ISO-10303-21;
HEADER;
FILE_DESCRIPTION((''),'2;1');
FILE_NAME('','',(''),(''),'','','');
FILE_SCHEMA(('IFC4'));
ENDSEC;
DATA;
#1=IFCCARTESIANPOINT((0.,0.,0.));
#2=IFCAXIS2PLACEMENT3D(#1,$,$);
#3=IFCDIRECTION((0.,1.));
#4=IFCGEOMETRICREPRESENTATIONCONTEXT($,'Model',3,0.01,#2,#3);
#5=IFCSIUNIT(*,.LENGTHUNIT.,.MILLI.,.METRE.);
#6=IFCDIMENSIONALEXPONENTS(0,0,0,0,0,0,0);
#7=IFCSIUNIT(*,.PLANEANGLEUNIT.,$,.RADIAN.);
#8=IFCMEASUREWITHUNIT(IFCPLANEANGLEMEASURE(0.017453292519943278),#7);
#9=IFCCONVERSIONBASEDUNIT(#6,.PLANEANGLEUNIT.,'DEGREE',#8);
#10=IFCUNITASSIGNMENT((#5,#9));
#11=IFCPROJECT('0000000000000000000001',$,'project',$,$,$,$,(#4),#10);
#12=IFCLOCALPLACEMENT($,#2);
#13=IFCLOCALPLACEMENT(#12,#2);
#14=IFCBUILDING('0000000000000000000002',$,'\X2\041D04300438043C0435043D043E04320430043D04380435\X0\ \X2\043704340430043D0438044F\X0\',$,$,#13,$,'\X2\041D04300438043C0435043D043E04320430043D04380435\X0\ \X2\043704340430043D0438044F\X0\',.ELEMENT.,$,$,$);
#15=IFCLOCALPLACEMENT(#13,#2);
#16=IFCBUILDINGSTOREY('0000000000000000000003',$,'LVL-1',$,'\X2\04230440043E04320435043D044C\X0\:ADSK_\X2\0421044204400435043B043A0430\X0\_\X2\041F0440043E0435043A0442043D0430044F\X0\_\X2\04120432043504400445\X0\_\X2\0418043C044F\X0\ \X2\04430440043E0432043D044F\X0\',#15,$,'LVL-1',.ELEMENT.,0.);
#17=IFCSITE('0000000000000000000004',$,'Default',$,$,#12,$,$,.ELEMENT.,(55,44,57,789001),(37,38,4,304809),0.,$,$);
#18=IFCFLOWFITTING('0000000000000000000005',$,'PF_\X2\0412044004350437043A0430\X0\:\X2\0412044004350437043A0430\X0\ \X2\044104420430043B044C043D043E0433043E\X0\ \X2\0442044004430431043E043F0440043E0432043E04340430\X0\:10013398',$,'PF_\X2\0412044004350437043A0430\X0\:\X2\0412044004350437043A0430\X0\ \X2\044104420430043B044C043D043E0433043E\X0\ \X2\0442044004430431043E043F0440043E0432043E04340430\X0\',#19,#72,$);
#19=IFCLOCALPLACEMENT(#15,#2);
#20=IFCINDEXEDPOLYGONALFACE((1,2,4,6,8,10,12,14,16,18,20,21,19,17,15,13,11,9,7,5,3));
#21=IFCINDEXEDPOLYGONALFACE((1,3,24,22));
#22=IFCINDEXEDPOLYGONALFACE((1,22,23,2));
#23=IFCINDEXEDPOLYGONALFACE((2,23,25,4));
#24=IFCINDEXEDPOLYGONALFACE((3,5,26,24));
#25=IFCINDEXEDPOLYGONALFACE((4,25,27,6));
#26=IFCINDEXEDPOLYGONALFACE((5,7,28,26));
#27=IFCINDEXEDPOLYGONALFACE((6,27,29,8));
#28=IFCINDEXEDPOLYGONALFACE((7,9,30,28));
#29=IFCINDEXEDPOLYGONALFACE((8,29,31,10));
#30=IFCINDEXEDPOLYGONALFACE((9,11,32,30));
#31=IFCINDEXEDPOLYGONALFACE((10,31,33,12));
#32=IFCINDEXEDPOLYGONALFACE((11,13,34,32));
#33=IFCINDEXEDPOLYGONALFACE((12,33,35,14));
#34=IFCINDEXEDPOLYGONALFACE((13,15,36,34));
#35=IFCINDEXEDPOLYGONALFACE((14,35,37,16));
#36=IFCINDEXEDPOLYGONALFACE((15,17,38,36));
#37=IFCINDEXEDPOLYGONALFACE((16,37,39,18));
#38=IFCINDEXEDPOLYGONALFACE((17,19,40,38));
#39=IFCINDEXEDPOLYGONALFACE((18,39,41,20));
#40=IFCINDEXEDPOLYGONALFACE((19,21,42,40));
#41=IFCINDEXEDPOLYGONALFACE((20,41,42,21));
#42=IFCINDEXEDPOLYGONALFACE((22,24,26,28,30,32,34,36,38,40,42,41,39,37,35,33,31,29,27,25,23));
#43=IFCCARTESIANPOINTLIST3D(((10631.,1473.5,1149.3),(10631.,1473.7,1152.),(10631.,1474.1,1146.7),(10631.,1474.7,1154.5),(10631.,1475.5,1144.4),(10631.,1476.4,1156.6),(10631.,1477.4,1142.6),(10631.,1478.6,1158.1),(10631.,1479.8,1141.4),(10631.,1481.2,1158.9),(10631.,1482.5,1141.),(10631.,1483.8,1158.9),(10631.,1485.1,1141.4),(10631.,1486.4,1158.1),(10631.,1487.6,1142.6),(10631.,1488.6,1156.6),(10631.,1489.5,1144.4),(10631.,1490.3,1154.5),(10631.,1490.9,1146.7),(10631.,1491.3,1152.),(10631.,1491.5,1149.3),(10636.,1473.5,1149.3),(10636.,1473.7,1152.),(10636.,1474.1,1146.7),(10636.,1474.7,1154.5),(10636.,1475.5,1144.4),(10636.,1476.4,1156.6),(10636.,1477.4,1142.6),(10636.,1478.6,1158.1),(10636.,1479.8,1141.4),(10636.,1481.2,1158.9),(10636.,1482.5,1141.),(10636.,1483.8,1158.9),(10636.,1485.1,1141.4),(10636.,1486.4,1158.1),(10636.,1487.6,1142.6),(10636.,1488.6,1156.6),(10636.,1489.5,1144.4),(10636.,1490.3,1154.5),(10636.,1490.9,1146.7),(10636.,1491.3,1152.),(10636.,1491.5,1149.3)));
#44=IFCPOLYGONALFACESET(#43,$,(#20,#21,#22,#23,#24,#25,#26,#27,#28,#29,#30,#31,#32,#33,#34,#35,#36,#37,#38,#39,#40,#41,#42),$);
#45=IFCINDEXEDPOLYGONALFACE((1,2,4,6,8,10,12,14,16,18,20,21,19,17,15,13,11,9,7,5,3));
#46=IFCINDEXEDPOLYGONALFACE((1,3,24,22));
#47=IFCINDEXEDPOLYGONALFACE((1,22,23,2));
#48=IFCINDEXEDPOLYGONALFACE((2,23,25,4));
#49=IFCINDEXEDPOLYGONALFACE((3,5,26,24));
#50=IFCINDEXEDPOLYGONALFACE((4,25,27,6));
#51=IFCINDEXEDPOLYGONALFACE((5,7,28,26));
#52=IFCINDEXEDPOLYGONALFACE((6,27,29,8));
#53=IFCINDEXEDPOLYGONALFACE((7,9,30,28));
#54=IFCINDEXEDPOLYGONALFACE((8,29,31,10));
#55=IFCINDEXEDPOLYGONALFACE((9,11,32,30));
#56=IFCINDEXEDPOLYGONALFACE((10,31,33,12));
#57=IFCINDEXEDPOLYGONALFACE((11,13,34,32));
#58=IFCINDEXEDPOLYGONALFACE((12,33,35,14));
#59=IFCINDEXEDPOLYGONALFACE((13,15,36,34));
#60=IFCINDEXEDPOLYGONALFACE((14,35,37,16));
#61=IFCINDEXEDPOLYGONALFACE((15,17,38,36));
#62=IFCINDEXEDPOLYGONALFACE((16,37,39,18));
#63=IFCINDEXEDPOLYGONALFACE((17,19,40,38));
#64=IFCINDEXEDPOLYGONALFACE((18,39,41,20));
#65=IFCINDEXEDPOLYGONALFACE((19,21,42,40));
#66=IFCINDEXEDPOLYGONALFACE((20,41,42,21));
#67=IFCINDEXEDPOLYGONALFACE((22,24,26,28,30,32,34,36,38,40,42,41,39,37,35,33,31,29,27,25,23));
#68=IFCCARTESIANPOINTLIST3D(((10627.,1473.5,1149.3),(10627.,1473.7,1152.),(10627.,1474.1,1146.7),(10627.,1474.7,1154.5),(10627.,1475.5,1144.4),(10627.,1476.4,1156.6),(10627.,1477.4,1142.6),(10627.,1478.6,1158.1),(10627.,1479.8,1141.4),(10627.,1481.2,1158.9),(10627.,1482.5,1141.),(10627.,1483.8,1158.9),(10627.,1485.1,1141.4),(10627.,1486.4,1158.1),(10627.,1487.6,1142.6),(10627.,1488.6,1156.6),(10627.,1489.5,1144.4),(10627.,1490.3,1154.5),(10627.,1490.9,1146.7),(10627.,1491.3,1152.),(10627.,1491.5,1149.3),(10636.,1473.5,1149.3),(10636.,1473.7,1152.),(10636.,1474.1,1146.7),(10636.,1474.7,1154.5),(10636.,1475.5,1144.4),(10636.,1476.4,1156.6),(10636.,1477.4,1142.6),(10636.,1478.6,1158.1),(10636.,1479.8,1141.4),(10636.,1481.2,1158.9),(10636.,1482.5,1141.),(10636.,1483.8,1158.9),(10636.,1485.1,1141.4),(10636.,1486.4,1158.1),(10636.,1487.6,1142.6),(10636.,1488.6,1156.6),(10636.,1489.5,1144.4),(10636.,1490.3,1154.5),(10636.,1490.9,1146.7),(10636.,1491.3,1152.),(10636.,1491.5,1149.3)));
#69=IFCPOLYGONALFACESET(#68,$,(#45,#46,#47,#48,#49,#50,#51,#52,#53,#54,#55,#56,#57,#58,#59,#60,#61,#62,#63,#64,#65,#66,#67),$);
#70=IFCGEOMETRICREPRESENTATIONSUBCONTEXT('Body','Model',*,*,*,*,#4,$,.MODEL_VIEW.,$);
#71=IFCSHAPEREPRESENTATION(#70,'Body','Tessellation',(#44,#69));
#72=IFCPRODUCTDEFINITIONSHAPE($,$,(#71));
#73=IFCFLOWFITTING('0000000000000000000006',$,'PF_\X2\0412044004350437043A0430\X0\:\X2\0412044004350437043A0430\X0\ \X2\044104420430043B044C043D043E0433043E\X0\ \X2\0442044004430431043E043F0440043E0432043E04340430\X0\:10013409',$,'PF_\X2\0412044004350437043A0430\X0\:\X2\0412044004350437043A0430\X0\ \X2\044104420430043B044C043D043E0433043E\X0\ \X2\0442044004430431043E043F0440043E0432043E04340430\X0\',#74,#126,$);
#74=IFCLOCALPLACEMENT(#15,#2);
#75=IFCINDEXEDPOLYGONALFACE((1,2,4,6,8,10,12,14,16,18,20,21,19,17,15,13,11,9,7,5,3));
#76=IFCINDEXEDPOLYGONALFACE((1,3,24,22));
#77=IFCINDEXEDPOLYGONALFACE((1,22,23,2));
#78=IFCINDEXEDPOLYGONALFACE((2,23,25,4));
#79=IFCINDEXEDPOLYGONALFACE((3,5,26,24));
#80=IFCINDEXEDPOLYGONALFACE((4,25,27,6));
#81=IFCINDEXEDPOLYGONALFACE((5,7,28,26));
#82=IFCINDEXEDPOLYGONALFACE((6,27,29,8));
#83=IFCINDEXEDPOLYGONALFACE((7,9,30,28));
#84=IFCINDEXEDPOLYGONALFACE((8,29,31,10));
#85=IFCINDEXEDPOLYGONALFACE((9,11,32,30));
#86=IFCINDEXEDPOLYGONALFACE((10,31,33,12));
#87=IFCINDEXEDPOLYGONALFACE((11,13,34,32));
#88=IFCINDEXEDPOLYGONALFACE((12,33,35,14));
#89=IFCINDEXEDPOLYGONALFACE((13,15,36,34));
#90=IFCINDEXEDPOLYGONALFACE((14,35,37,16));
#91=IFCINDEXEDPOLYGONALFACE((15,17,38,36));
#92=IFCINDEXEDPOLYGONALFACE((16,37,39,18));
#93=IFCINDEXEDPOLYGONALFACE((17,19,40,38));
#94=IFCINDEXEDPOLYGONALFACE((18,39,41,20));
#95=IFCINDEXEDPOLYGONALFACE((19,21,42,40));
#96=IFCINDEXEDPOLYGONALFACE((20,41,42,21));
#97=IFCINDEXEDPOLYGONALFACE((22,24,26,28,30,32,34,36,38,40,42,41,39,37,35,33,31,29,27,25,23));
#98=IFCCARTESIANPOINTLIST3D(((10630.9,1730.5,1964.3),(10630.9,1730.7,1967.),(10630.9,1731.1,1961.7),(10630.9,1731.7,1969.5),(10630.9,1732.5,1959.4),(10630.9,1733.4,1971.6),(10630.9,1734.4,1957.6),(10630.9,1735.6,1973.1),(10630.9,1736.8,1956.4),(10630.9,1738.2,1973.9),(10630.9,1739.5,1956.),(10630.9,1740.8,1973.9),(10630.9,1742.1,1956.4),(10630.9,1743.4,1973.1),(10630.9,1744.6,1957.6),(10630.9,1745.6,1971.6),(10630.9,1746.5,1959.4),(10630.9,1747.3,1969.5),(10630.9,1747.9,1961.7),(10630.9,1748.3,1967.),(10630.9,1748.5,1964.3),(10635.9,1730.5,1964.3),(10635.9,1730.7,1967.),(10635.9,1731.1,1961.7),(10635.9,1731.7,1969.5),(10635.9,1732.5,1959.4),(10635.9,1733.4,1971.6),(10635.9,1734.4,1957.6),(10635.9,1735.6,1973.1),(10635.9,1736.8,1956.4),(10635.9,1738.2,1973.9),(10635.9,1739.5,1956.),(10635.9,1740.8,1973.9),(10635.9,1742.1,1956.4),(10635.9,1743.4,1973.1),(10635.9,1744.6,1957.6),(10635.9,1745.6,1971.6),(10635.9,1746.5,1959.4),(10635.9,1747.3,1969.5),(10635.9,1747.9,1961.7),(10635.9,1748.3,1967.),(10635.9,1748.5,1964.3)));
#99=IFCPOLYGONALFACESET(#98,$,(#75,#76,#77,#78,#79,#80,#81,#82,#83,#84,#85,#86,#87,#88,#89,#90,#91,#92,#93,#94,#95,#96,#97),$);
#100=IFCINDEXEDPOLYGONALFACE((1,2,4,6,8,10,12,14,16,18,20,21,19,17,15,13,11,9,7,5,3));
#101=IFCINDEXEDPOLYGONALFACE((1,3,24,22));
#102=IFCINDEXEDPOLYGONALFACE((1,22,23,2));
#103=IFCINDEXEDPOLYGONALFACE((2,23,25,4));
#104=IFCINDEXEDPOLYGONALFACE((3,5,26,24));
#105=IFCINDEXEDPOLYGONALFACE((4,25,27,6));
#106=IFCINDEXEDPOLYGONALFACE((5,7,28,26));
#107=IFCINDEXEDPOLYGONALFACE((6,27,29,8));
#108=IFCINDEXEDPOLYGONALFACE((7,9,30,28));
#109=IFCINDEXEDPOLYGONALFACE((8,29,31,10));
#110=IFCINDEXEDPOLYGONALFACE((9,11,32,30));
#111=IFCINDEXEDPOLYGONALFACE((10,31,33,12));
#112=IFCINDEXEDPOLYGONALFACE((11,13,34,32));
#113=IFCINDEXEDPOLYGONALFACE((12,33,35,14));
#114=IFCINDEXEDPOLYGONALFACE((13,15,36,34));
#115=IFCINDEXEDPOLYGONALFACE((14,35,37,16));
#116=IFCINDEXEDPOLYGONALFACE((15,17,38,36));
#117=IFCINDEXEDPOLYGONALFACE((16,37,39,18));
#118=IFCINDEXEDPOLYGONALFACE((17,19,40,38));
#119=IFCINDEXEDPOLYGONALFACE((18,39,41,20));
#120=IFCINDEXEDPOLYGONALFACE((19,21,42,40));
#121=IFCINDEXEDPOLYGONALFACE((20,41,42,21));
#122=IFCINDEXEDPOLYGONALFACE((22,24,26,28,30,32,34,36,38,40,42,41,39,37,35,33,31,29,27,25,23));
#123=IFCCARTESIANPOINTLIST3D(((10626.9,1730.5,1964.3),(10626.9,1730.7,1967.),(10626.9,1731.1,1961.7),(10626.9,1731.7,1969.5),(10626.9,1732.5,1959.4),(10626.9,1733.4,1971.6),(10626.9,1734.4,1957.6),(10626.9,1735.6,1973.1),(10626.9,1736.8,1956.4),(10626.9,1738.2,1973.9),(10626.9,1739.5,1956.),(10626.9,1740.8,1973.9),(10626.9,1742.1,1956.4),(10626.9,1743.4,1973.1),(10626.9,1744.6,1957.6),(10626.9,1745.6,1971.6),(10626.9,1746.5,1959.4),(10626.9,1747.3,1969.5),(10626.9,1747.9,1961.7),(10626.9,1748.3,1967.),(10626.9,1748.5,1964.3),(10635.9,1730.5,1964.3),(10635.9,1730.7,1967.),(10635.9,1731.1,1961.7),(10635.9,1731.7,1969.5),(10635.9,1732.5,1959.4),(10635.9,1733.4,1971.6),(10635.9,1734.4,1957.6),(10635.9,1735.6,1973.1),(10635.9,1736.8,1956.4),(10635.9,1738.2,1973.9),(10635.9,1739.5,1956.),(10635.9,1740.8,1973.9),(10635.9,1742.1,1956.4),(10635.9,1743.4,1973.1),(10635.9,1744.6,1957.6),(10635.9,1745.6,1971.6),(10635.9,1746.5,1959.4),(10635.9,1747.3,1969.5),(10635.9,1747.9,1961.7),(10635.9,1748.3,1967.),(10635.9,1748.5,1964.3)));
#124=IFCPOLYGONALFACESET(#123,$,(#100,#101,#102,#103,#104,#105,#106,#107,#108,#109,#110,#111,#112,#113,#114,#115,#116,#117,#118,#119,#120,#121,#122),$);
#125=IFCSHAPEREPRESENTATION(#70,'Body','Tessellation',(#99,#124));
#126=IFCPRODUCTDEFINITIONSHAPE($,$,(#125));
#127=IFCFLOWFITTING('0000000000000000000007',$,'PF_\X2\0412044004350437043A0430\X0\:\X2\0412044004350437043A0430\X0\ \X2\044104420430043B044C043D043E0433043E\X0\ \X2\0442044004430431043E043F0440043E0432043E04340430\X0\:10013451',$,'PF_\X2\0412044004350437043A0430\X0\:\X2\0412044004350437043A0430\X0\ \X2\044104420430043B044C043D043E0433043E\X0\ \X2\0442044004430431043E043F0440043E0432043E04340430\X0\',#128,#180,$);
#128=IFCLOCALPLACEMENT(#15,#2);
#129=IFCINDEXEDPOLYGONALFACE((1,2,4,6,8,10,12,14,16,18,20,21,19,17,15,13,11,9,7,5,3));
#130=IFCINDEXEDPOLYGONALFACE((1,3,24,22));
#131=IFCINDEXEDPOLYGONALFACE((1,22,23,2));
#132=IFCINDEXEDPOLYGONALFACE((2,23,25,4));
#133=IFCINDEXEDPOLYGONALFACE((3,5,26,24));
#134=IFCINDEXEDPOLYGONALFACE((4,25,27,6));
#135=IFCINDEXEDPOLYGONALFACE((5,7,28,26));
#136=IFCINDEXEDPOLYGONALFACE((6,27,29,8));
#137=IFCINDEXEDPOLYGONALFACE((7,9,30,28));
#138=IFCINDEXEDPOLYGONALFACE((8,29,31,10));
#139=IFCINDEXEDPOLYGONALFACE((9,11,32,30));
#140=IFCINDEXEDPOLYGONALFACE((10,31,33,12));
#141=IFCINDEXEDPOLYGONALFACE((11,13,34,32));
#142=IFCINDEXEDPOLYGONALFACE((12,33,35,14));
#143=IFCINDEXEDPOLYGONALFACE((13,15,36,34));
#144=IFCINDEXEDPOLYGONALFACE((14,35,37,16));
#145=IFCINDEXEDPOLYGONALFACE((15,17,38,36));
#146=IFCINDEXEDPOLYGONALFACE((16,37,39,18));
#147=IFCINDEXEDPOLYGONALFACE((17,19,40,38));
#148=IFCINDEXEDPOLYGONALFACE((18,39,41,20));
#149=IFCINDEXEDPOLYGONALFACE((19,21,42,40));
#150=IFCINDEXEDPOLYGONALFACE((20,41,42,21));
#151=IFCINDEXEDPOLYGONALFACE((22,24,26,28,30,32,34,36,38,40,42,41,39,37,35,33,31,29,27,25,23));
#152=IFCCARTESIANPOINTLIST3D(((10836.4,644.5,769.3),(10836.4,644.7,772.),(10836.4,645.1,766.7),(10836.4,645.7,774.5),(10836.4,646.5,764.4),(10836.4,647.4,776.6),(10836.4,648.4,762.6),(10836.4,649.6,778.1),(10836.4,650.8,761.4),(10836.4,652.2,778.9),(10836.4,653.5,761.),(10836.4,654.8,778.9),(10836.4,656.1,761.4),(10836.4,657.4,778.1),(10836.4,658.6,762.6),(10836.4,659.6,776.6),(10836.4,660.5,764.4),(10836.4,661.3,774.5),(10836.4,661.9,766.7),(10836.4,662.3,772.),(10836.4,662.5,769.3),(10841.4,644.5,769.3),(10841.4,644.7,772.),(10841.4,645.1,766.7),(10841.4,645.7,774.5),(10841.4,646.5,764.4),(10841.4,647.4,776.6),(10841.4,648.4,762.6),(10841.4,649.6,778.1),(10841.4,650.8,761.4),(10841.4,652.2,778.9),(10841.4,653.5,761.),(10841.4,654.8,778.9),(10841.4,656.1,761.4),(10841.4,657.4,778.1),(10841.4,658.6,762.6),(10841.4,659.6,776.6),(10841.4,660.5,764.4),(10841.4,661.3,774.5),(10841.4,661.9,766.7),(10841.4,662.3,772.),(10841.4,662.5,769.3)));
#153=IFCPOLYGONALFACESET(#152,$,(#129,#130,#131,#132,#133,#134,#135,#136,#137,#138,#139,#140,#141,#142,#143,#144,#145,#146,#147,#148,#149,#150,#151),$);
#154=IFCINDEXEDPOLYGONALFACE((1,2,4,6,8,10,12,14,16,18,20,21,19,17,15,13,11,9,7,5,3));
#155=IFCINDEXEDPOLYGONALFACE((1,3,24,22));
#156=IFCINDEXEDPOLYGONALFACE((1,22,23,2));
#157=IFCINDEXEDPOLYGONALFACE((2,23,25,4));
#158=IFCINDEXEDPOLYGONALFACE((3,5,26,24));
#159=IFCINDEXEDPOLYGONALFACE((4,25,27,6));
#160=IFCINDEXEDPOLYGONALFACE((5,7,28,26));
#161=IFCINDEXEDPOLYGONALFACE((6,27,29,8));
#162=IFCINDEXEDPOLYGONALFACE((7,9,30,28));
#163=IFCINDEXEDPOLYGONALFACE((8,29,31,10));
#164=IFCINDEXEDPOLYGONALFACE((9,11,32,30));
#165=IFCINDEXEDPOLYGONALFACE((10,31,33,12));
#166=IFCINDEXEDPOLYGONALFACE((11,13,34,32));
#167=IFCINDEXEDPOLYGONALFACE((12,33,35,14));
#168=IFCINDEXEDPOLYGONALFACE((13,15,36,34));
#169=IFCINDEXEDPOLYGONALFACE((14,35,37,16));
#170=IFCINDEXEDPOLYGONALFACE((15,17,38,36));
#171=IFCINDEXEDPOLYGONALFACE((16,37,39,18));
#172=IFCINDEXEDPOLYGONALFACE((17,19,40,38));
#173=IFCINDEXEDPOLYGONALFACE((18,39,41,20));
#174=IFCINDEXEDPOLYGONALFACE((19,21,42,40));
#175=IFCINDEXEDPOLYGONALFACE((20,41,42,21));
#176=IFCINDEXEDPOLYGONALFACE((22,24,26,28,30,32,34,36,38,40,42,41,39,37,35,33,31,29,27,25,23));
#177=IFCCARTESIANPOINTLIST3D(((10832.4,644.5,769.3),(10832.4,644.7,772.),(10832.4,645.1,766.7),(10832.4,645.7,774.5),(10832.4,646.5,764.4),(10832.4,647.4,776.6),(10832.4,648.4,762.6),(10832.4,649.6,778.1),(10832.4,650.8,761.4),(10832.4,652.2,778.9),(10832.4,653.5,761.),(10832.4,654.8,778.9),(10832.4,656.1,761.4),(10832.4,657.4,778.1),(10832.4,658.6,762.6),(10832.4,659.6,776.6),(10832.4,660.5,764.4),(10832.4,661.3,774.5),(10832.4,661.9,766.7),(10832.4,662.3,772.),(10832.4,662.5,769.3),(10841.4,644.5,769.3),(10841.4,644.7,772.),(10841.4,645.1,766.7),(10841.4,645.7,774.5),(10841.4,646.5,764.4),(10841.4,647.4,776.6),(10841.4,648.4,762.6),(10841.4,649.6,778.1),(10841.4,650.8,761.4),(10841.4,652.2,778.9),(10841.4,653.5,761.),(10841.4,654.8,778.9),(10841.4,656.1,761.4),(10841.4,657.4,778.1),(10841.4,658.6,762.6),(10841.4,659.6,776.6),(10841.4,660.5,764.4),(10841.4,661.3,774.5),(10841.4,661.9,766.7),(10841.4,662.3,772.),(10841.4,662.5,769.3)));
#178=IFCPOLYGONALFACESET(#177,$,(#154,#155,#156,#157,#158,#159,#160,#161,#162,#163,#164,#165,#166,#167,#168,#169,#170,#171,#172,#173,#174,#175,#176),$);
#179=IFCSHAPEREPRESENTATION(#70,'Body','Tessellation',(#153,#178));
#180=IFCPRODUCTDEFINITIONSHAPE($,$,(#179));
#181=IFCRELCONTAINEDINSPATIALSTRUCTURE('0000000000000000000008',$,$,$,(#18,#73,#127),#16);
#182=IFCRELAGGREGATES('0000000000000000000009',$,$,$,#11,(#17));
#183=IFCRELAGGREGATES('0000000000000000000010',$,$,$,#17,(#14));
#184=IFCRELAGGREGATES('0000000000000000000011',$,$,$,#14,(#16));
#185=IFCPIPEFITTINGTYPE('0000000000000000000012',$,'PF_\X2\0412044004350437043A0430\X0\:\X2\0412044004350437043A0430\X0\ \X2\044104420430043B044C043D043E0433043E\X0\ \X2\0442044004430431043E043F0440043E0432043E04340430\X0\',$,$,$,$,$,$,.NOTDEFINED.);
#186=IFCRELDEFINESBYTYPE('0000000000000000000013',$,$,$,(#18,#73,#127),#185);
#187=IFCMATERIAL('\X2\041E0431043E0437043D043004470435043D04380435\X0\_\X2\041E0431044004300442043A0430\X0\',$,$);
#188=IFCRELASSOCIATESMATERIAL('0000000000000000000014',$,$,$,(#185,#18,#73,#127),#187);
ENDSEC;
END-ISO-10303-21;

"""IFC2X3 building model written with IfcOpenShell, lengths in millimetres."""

from ifc_helpers import new_model, entity, si_unit, converted_unit, direction, frame, frame_2d, origin, place, context, subcontext, project, spatial, circle, extrude, source, transform, mapped, material, type_object, type_shapes, element, save


model = new_model("IFC2X3")

# Units and contexts
model_context = context("Model", 3, precision=0.01, world=origin(), true_north=direction((0.0, 1.0)))
body_context = subcontext(model_context, "Body", "Model", "MODEL_VIEW")
ifc_project = project(units=[si_unit("LENGTHUNIT", "METRE", prefix="MILLI"), converted_unit("PLANEANGLEUNIT", "DEGREE", entity("IfcPlaneAngleMeasure", 0.017453292519943278), si_unit("PLANEANGLEUNIT", "RADIAN"), dimensions=[0, 0, 0, 0, 0, 0, 0])], contexts=[model_context])

# Site, building, storey
site_placement = place(None, origin())
site = spatial("IfcSite", under=ifc_project, at=site_placement, Name="Default", CompositionType="ELEMENT", RefLatitude=(55, 44, 57, 789001), RefLongitude=(37, 38, 4, 304809), RefElevation=0.0)
building_placement = place(site_placement, origin())
building = spatial("IfcBuilding", under=site, at=building_placement, Name="Наименование здания", LongName="Наименование здания", CompositionType="ELEMENT")
storey_placement = place(building_placement, origin())
storey = spatial("IfcBuildingStorey", under=building, at=storey_placement, Name="LVL-1", ObjectType="Уровень:ADSK_Стрелка_Проектная_Вверх_Имя уровня", LongName="LVL-1", CompositionType="ELEMENT", Elevation=0.0)

# Flow fittings
ifc_material_1 = material(Name="Обозначение_Обратка")
pipe_fitting_type_1 = type_object("IfcPipeFittingType", Name="PF_Врезка:Врезка стального трубопровода", PredefinedType="NOTDEFINED", material=ifc_material_1)
shared_shape_1 = source(origin(), body_context, "Body", "SweptSolid", [
    extrude(circle(Radius=9.0, at=frame_2d((0.0, 0.0), x_axis=(1.0, 0.0))), frame((-5.0, 0.0, 0.0), z_axis=(1.0, 0.0, 0.0), x_axis=(0.0, -1.0, 0.0)), (0.0, 0.0, 1.0), 5.0),
    extrude(circle(Radius=9.0, at=frame_2d((0.0, 0.0), x_axis=(1.0, 0.0))), frame((-9.0, 0.0, 0.0), z_axis=(1.0, 0.0, 0.0), x_axis=(0.0, -1.0, 0.0)), (0.0, 0.0, 1.0), 9.0),
])
type_shapes(pipe_fitting_type_1, [shared_shape_1])
for number, where, z_axis, x_axis, name in (
    (1, (10636.0, 1482.5, 1150.0), (0.0, -1.0, 0.0), (1.0, 0.0, 0.0), "PF_Врезка:Врезка стального трубопровода:10013398"),
    (2, (10635.9, 1739.5, 1965.0), (0.0, -1.0, 0.0), (1.0, 0.0, 0.0), "PF_Врезка:Врезка стального трубопровода:10013409"),
    (3, (10841.4, 653.5, 770.0), (0.0, -1.0, 0.0), (1.0, 0.0, 0.0), "PF_Врезка:Врезка стального трубопровода:10013451"),
):
    element("IfcFlowFitting", number, at=place(storey_placement, frame(where, z_axis=z_axis, x_axis=x_axis)), inside=storey, type_object=pipe_fitting_type_1, material=ifc_material_1, Name=name, ObjectType="PF_Врезка:Врезка стального трубопровода", context=body_context, shape_type="MappedRepresentation", body=[
        mapped(shared_shape_1, transform((0.0, 0.0, 0.0), scale=1.0)),
    ])

save(model, "model.ifc")
